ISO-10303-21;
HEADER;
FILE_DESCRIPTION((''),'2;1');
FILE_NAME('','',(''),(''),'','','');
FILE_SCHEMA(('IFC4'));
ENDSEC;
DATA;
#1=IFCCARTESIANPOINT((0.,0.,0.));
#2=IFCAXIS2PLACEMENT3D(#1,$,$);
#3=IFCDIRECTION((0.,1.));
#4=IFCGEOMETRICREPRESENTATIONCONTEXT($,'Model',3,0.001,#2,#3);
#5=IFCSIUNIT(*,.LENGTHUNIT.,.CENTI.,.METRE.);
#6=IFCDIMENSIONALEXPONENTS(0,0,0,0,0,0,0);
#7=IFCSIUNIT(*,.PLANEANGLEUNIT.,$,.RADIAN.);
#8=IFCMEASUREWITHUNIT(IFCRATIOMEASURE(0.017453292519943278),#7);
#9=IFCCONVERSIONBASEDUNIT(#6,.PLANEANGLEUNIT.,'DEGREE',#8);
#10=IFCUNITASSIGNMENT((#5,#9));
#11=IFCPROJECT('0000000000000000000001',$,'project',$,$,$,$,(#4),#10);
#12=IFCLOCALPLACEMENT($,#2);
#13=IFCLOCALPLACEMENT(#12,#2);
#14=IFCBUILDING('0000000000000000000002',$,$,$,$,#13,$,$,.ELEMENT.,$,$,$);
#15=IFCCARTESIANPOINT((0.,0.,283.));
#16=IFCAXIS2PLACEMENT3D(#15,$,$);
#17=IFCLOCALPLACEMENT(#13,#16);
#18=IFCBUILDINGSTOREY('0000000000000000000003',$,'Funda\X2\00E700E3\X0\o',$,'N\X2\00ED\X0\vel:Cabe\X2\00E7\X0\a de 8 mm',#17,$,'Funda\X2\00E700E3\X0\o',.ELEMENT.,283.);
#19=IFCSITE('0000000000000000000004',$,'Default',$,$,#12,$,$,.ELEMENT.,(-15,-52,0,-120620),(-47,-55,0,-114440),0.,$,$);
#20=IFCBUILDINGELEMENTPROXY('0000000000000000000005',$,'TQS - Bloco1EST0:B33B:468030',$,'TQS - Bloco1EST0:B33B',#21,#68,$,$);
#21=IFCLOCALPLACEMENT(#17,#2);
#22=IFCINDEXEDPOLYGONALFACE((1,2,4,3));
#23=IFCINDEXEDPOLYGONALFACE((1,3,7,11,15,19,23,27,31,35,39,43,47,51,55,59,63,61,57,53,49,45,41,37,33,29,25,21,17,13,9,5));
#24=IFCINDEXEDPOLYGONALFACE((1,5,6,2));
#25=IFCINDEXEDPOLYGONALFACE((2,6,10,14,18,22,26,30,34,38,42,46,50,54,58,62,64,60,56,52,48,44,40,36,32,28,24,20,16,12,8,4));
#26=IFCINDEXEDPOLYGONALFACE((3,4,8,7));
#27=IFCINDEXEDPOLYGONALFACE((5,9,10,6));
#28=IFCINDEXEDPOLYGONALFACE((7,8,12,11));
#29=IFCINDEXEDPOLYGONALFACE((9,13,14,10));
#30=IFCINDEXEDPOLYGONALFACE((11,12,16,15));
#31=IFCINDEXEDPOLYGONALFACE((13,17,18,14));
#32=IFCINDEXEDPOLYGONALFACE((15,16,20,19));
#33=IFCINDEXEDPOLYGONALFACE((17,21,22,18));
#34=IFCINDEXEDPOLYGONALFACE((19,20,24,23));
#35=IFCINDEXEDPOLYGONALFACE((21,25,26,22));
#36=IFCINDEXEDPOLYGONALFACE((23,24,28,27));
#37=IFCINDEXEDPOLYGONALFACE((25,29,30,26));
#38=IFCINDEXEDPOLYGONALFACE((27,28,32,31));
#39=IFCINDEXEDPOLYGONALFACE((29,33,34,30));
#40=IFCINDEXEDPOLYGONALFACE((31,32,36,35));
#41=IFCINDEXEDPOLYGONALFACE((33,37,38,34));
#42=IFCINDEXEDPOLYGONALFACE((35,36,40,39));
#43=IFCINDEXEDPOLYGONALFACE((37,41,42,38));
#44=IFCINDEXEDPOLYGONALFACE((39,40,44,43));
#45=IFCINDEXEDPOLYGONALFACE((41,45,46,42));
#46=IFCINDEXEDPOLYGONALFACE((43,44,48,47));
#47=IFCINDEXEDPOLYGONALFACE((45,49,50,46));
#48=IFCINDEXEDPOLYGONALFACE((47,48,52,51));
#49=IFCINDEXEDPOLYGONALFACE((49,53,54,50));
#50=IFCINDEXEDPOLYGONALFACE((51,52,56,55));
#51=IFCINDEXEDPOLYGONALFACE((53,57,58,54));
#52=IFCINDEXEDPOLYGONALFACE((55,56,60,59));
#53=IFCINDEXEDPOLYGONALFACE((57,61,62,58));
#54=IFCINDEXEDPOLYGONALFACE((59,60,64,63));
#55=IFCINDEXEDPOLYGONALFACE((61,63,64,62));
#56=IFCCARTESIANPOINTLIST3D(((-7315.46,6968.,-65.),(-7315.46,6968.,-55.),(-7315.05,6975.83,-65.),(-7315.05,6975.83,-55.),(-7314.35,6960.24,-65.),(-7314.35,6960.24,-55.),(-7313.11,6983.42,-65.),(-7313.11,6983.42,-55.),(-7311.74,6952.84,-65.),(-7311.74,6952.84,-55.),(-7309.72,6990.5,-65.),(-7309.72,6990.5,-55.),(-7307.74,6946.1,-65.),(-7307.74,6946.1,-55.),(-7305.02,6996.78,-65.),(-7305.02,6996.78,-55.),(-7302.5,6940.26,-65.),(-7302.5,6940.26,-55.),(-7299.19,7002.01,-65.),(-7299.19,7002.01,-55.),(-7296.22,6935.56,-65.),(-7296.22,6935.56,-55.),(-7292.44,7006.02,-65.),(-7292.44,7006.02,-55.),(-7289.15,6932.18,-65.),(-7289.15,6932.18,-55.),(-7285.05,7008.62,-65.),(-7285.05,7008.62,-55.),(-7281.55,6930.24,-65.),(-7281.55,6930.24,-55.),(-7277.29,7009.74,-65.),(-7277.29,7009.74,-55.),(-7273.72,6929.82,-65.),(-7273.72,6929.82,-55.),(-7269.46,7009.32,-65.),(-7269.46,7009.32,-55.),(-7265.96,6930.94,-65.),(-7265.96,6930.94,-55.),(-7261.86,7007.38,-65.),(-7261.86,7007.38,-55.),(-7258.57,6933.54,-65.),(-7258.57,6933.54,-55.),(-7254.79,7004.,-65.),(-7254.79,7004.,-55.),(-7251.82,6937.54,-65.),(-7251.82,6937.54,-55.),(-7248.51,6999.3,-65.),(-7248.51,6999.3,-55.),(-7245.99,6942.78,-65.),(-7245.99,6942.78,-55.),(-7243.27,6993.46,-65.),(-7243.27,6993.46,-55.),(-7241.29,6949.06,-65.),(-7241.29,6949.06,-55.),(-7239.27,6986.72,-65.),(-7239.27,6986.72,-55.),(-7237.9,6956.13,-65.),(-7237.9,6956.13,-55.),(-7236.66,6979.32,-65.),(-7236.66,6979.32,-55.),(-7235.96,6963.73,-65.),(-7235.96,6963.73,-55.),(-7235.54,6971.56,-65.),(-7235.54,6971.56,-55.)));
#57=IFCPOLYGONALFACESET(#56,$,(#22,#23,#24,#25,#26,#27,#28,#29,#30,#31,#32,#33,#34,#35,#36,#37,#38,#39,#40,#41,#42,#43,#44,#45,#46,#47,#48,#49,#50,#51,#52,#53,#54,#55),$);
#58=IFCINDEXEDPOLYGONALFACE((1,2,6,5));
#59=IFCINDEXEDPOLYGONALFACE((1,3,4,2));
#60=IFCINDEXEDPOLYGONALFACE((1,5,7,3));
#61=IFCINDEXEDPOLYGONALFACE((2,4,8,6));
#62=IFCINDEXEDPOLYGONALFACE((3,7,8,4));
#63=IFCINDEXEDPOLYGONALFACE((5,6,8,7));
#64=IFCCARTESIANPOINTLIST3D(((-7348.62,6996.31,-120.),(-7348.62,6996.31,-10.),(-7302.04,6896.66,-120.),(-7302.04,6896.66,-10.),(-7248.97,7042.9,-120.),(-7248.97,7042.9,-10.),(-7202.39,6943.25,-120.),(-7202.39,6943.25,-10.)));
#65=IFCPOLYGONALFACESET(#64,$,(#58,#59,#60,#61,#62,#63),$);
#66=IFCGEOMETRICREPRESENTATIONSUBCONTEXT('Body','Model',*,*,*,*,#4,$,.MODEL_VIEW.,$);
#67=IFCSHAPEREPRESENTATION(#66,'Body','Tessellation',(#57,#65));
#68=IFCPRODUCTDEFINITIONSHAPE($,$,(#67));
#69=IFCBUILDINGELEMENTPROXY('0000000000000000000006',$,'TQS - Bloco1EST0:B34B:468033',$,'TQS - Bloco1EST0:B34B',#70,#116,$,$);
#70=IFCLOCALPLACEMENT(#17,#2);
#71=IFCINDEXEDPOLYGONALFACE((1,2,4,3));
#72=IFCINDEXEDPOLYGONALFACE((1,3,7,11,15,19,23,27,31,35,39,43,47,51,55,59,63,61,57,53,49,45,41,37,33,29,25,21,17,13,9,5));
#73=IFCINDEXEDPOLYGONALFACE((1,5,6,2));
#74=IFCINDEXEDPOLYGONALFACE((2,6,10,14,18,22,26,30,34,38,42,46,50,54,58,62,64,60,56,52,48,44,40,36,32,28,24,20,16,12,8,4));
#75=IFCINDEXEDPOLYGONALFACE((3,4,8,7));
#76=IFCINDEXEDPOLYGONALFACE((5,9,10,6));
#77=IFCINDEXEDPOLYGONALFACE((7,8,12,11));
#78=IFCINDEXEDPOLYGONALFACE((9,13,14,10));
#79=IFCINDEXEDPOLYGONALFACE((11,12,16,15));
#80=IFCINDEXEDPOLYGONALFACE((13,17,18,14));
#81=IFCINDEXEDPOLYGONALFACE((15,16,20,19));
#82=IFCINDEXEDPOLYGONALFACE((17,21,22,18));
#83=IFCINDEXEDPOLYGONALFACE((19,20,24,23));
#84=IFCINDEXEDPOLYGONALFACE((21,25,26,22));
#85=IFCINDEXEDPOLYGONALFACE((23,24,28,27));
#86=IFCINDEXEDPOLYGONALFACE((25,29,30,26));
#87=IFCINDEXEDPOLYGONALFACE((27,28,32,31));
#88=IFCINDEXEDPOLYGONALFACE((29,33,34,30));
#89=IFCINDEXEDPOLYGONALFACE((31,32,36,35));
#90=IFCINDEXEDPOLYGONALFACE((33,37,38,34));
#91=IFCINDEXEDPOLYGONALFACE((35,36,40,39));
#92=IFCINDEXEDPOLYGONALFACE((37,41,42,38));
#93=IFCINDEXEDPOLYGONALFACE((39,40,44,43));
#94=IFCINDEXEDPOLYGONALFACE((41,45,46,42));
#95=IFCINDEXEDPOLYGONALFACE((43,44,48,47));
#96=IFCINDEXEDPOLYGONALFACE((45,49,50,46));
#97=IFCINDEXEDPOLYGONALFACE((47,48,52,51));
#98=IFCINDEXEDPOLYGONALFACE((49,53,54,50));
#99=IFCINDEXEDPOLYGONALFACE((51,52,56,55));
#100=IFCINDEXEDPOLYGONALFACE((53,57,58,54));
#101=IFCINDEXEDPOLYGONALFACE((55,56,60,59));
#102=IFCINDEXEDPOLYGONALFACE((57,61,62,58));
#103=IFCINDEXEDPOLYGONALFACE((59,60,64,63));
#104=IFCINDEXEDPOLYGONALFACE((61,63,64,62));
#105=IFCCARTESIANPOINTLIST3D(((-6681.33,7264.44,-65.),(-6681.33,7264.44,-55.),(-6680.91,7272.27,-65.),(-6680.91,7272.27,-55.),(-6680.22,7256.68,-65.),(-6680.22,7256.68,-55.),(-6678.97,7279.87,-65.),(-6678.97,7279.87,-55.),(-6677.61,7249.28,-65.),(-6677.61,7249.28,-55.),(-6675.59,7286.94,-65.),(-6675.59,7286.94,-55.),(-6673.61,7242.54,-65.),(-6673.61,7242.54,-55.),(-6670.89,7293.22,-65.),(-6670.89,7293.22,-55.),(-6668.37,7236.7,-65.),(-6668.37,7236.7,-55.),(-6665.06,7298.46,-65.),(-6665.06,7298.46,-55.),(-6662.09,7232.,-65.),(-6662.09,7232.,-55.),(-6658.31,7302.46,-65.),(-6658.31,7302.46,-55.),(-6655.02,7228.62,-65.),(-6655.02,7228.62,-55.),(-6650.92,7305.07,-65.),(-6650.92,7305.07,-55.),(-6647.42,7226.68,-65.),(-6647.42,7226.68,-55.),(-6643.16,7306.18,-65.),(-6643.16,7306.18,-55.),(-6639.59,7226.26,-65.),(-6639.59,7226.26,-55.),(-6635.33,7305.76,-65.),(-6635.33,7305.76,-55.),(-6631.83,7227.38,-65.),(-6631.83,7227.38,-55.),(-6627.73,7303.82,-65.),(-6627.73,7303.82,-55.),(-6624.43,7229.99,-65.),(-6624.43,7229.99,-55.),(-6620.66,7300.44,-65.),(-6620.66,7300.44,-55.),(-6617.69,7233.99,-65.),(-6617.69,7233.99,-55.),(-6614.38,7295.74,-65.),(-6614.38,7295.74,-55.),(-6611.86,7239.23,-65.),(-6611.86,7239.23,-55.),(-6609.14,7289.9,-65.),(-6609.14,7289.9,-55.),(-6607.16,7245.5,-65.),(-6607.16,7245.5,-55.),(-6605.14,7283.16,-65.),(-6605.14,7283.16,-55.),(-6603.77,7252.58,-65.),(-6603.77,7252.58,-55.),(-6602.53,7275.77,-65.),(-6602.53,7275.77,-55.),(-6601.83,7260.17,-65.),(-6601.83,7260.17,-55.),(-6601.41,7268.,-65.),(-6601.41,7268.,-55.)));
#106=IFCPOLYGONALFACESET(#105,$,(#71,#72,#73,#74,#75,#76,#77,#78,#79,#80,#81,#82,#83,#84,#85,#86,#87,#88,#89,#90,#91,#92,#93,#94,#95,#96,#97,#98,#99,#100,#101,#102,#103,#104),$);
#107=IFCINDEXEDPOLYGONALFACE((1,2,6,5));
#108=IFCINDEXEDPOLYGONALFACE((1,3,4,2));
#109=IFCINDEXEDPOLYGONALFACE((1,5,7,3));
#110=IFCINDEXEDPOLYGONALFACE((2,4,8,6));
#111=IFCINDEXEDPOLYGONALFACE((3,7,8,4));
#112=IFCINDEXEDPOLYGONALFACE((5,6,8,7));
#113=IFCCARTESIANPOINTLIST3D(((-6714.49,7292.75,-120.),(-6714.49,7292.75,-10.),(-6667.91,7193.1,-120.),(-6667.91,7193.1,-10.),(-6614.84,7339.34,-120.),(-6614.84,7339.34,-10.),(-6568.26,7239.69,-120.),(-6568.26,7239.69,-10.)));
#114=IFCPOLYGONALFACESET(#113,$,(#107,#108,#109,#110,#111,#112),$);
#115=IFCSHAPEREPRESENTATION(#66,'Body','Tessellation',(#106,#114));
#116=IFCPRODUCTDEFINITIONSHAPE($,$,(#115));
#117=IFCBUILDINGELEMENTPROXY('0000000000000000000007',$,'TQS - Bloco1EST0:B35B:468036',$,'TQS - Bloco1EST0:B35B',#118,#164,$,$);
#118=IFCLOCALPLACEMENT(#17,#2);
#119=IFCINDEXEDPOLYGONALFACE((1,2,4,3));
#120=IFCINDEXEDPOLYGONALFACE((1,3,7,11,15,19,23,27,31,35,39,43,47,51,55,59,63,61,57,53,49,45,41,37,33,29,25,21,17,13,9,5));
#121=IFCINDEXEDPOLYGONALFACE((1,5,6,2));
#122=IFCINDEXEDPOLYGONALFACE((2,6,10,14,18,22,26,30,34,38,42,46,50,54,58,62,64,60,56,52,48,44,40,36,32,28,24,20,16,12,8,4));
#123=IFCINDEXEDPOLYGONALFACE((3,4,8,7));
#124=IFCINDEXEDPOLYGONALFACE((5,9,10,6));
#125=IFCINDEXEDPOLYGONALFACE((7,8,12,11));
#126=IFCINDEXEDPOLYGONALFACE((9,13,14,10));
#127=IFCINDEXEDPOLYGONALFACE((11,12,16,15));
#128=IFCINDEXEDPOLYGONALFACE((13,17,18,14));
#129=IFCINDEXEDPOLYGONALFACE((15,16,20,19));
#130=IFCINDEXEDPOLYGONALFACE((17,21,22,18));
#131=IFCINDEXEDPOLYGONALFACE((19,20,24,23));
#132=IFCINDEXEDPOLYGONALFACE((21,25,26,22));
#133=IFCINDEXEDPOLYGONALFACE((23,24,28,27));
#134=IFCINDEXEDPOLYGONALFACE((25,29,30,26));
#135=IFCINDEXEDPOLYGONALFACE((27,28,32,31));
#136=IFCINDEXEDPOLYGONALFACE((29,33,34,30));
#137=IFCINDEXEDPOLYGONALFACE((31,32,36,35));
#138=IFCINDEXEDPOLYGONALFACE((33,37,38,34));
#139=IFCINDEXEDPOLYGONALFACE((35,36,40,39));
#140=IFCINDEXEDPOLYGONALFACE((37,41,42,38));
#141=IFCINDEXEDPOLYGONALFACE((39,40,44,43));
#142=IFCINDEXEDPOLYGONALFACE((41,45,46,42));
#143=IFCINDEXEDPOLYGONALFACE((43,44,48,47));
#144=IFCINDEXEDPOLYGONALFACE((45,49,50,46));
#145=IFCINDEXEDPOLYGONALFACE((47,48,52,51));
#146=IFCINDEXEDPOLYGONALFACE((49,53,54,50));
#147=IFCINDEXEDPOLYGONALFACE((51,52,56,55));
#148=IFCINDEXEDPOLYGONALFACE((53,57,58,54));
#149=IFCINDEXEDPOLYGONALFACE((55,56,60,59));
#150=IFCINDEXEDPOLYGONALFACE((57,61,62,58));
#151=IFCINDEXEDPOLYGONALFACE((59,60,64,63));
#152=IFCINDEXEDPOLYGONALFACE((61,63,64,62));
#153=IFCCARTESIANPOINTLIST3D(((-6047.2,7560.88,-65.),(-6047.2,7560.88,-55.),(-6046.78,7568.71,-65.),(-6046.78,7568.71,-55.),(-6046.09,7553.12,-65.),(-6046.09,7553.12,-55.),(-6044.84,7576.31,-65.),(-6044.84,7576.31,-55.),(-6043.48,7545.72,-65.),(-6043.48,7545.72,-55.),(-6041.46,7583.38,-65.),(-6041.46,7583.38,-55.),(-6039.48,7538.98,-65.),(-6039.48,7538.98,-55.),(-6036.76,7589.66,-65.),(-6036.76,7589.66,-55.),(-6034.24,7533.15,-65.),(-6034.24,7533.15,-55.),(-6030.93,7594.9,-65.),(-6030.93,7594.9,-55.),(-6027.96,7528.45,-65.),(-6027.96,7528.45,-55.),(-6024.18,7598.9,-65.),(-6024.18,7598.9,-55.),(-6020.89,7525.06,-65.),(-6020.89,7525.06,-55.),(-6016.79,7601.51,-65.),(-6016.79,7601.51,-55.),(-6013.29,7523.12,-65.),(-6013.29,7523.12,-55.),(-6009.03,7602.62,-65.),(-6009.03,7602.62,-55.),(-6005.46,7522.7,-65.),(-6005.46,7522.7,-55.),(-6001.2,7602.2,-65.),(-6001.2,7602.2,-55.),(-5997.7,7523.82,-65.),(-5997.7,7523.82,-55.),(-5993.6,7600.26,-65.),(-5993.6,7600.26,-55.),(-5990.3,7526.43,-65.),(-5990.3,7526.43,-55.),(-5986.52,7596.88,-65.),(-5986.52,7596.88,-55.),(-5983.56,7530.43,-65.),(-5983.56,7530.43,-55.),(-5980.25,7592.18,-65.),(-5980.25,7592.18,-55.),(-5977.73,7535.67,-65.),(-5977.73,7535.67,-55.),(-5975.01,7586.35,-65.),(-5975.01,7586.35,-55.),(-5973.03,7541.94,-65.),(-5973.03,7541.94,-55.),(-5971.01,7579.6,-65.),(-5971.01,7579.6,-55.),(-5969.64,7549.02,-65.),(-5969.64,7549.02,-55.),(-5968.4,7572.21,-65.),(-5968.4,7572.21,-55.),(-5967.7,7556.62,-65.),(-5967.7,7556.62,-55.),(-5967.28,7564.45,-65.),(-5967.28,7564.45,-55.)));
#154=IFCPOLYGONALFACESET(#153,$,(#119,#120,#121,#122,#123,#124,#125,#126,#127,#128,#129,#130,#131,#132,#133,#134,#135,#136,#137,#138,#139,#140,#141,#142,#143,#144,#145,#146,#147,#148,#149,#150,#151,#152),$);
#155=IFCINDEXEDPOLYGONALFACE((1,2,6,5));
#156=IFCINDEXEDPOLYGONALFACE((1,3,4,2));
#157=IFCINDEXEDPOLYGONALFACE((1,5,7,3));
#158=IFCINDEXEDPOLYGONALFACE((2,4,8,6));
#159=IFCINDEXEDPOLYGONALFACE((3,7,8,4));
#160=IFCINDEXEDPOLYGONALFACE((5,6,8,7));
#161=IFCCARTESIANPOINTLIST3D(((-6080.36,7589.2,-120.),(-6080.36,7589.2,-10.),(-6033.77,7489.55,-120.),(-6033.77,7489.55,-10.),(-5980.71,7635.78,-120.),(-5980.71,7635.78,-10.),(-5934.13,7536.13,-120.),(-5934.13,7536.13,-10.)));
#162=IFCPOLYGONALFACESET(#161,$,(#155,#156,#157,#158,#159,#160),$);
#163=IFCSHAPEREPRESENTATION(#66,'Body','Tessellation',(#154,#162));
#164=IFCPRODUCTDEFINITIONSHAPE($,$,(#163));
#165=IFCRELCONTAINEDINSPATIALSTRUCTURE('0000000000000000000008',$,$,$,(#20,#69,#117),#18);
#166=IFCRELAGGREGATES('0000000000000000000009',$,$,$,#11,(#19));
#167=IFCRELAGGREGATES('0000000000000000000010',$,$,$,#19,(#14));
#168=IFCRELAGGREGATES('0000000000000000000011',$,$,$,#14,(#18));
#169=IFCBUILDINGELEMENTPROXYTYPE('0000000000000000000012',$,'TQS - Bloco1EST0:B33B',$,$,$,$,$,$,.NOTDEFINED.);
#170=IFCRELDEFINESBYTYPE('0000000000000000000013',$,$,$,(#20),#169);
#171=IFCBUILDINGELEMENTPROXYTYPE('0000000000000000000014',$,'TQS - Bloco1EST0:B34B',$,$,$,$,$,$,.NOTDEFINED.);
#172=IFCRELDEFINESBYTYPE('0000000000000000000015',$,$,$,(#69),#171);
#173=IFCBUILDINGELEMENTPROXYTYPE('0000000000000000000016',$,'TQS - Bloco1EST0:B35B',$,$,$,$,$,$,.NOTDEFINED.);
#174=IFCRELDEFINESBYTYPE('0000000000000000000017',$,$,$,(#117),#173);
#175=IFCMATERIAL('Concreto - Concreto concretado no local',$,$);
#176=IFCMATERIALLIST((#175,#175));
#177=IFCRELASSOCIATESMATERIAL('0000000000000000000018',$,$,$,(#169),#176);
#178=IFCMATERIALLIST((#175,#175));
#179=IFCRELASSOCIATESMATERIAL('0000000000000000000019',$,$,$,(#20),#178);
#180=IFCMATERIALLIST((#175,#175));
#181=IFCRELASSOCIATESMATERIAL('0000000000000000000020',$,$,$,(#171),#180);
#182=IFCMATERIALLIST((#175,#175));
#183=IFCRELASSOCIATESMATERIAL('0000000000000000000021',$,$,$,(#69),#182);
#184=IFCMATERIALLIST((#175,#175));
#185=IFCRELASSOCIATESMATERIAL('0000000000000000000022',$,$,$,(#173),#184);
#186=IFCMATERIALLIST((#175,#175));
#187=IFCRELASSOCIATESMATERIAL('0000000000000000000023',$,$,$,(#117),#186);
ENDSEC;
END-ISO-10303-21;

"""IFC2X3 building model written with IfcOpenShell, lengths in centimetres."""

from ifc_helpers import new_model, entity, si_unit, converted_unit, direction, frame, frame_2d, origin, origin_2d_with_axis, place, context, subcontext, project, spatial, rectangle, circle, extrude, source, transform, mapped, material, material_list, type_object, type_shapes, element, save


model = new_model("IFC2X3")

# Units and contexts
model_context = context("Model", 3, precision=0.001, world=origin(), true_north=direction((0.0, 1.0)))
body_context = subcontext(model_context, "Body", "Model", "MODEL_VIEW")
ifc_project = project(units=[si_unit("LENGTHUNIT", "METRE", prefix="CENTI"), converted_unit("PLANEANGLEUNIT", "DEGREE", entity("IfcRatioMeasure", 0.017453292519943278), si_unit("PLANEANGLEUNIT", "RADIAN"), dimensions=[0, 0, 0, 0, 0, 0, 0])], contexts=[model_context])

# Site, building, storey
site_placement = place(None, origin())
site = spatial("IfcSite", under=ifc_project, at=site_placement, Name="Default", CompositionType="ELEMENT", RefLatitude=(-15, -52, 0, -120620), RefLongitude=(-47, -55, 0, -114440), RefElevation=0.0)
building_placement = place(site_placement, origin())
building = spatial("IfcBuilding", under=site, at=building_placement, CompositionType="ELEMENT")
storey_placement = place(building_placement, frame((0.0, 0.0, 283.0)))
storey = spatial("IfcBuildingStorey", under=building, at=storey_placement, Name="Fundação", ObjectType="Nível:Cabeça de 8 mm", LongName="Fundação", CompositionType="ELEMENT", Elevation=283.0)

# Building element proxies
ifc_material_1 = material(Name="Concreto - Concreto concretado no local")
ifc_material_list_1 = material_list([ifc_material_1, ifc_material_1])
ifc_material_list_2 = material_list([ifc_material_1, ifc_material_1])
building_element_proxy_type_1 = type_object("IfcBuildingElementProxyType", Name="TQS - Bloco1EST0:B33B", PredefinedType="NOTDEFINED", material=ifc_material_list_2)
shared_shape_1 = source(origin(), body_context, "Body", "SweptSolid", [
    extrude(circle(Radius=40.0, at=frame_2d((0.0, 0.0), x_axis=(1.0, 0.0))), frame((0.0, 0.0, -55.0)), (0.0, 0.0, 1.0), 10.0),
    extrude(rectangle(XDim=110.0, YDim=110.0, at=origin_2d_with_axis()), frame((0.0, 0.0, -110.0), z_axis=(0.0, 0.0, 1.0), x_axis=(-1.0, 0.0, 0.0)), (0.0, 0.0, 1.0), 110.0),
])
type_shapes(building_element_proxy_type_1, [shared_shape_1])
proxy_1_placement = place(storey_placement, frame((-7275.5, 6969.78, -10.0), z_axis=(0.0, 0.0, 1.0), x_axis=(0.905902, 0.423488, 0.0)))
element("IfcBuildingElementProxy", 1, at=proxy_1_placement, inside=storey, type_object=building_element_proxy_type_1, material=ifc_material_list_1, Name="TQS - Bloco1EST0:B33B:468030", ObjectType="TQS - Bloco1EST0:B33B", context=body_context, shape_type="MappedRepresentation", body=[
    mapped(shared_shape_1, transform((0.0, 0.0, 0.0), scale=1.0)),
])
ifc_material_list_3 = material_list([ifc_material_1, ifc_material_1])
ifc_material_list_4 = material_list([ifc_material_1, ifc_material_1])
building_element_proxy_type_2 = type_object("IfcBuildingElementProxyType", Name="TQS - Bloco1EST0:B34B", PredefinedType="NOTDEFINED", material=ifc_material_list_4)
shared_shape_2 = source(origin(), body_context, "Body", "SweptSolid", [
    extrude(circle(Radius=40.0, at=frame_2d((0.0, 0.0), x_axis=(1.0, 0.0))), frame((0.0, 0.0, -55.0)), (0.0, 0.0, 1.0), 10.0),
    extrude(rectangle(XDim=110.0, YDim=110.0, at=origin_2d_with_axis()), frame((0.0, 0.0, -110.0), z_axis=(0.0, 0.0, 1.0), x_axis=(-1.0, 0.0, 0.0)), (0.0, 0.0, 1.0), 110.0),
])
type_shapes(building_element_proxy_type_2, [shared_shape_2])
proxy_2_placement = place(storey_placement, frame((-6641.37, 7266.22, -10.0), z_axis=(0.0, 0.0, 1.0), x_axis=(0.905902, 0.423488, 0.0)))
element("IfcBuildingElementProxy", 2, at=proxy_2_placement, inside=storey, type_object=building_element_proxy_type_2, material=ifc_material_list_3, Name="TQS - Bloco1EST0:B34B:468033", ObjectType="TQS - Bloco1EST0:B34B", context=body_context, shape_type="MappedRepresentation", body=[
    mapped(shared_shape_2, transform((0.0, 0.0, 0.0), scale=1.0)),
])
ifc_material_list_5 = material_list([ifc_material_1, ifc_material_1])
ifc_material_list_6 = material_list([ifc_material_1, ifc_material_1])
building_element_proxy_type_3 = type_object("IfcBuildingElementProxyType", Name="TQS - Bloco1EST0:B35B", PredefinedType="NOTDEFINED", material=ifc_material_list_6)
shared_shape_3 = source(origin(), body_context, "Body", "SweptSolid", [
    extrude(circle(Radius=40.0, at=frame_2d((0.0, 0.0), x_axis=(1.0, 0.0))), frame((0.0, 0.0, -55.0)), (0.0, 0.0, 1.0), 10.0),
    extrude(rectangle(XDim=110.0, YDim=110.0, at=origin_2d_with_axis()), frame((0.0, 0.0, -110.0), z_axis=(0.0, 0.0, 1.0), x_axis=(-1.0, 0.0, 0.0)), (0.0, 0.0, 1.0), 110.0),
])
type_shapes(building_element_proxy_type_3, [shared_shape_3])
proxy_3_placement = place(storey_placement, frame((-6007.24, 7562.66, -10.0), z_axis=(0.0, 0.0, 1.0), x_axis=(0.905902, 0.423488, 0.0)))
element("IfcBuildingElementProxy", 3, at=proxy_3_placement, inside=storey, type_object=building_element_proxy_type_3, material=ifc_material_list_5, Name="TQS - Bloco1EST0:B35B:468036", ObjectType="TQS - Bloco1EST0:B35B", context=body_context, shape_type="MappedRepresentation", body=[
    mapped(shared_shape_3, transform((0.0, 0.0, 0.0), scale=1.0)),
])

save(model, "model.ifc")
